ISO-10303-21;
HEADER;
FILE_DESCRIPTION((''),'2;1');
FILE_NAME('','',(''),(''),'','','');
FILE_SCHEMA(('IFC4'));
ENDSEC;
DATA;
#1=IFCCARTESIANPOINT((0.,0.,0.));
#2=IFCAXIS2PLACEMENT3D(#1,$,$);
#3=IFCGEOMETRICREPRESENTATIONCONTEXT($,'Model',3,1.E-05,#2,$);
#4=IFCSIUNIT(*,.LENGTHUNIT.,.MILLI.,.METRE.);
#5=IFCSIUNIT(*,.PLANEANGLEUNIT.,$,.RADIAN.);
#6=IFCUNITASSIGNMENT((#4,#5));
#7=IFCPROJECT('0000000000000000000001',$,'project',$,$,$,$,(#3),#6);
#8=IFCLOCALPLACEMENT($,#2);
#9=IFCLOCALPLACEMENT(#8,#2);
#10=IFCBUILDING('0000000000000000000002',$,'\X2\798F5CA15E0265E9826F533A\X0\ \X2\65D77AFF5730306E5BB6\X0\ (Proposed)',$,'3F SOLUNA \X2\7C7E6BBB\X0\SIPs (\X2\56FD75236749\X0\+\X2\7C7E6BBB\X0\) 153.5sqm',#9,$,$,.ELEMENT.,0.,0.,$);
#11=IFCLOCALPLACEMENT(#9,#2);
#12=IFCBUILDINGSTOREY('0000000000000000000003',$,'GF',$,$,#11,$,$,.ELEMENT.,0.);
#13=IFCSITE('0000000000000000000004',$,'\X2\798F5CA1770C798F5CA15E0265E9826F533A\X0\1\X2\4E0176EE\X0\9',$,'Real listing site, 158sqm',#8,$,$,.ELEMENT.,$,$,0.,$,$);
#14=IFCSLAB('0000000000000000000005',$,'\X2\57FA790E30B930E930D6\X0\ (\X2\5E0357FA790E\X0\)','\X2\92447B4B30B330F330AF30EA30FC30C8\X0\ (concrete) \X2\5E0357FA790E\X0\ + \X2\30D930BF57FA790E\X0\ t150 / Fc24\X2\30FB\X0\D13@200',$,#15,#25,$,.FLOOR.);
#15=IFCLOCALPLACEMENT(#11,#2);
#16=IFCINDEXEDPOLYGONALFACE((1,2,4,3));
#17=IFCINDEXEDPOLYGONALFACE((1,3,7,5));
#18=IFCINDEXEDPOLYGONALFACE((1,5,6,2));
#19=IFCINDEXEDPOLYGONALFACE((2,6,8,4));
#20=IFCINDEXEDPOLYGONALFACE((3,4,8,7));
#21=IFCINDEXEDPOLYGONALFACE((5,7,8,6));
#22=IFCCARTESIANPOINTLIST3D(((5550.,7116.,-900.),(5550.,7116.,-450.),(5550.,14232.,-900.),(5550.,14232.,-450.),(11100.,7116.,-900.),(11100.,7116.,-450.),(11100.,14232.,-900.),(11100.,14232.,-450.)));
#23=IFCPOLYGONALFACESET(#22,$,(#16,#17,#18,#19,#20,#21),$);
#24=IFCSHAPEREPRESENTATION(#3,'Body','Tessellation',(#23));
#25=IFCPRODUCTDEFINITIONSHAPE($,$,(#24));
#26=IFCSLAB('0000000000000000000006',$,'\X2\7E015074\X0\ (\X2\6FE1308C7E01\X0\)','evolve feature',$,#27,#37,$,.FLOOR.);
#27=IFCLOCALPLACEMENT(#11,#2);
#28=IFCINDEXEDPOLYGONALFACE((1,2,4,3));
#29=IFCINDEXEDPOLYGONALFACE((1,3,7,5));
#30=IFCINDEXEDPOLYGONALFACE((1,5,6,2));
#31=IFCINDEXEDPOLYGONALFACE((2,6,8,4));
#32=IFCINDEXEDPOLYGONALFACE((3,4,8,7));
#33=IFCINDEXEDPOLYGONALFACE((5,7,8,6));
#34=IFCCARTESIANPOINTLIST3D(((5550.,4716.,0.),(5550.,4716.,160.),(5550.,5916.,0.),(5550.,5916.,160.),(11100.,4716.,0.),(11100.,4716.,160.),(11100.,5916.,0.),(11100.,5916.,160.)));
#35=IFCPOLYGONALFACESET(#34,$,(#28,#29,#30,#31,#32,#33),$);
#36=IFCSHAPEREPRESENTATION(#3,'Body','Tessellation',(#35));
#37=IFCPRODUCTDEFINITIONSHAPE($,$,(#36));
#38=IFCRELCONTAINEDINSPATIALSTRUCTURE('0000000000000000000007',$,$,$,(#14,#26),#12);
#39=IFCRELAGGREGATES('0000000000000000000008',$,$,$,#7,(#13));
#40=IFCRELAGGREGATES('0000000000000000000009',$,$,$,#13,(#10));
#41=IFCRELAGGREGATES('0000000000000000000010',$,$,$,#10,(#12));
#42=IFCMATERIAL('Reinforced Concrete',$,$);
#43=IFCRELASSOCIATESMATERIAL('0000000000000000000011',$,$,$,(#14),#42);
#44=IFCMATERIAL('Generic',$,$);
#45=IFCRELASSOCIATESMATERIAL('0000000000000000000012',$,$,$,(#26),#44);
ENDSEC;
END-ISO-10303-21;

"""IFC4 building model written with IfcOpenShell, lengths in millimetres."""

from ifc_helpers import new_model, si_unit, frame, frame_2d, origin, place, context, project, spatial, rectangle, extrude, material, element, save


model = new_model("IFC4")

# Units and contexts
model_context = context("Model", 3, precision=1e-05, world=origin())
ifc_project = project(units=[si_unit("LENGTHUNIT", "METRE", prefix="MILLI"), si_unit("PLANEANGLEUNIT", "RADIAN")], contexts=[model_context])

# Site, building, storey
site_placement = place(None, origin())
site = spatial("IfcSite", under=ifc_project, at=site_placement, Name="福岡県福岡市早良区1丁目9", ObjectType="Real listing site, 158sqm", CompositionType="ELEMENT", RefElevation=0.0)
building_placement = place(site_placement, origin())
building = spatial("IfcBuilding", under=site, at=building_placement, Name="福岡市早良区 旗竿地の家 (Proposed)", ObjectType="3F SOLUNA 籾殻SIPs (国産杉+籾殻) 153.5sqm", CompositionType="ELEMENT", ElevationOfRefHeight=0.0, ElevationOfTerrain=0.0)
storey_placement = place(building_placement, origin())
storey = spatial("IfcBuildingStorey", under=building, at=storey_placement, Name="GF", CompositionType="ELEMENT", Elevation=0.0)

# Slabs
ifc_material_1 = material(Name="Reinforced Concrete")
slab_1_placement = place(storey_placement, frame((2775.0, 3558.0, -450.0)))
element("IfcSlab", 1, at=slab_1_placement, inside=storey, material=ifc_material_1, Name="基礎スラブ (布基礎)", Description="鉄筋コンクリート (concrete) 布基礎 + ベタ基礎 t150 / Fc24・D13@200", PredefinedType="FLOOR", context=model_context, shape_type="SweptSolid", body=[
    extrude(rectangle(XDim=5550.0, YDim=7116.0, at=frame_2d((2775.0, 3558.0))), frame((2775.0, 3558.0, -450.0)), (0.0, 0.0, 1.0), 450.0),
])
ifc_material_2 = material(Name="Generic")
slab_2_placement = place(storey_placement, frame((2775.0, 2358.0, 0.0)))
element("IfcSlab", 2, at=slab_2_placement, inside=storey, material=ifc_material_2, Name="縁側 (濡れ縁)", Description="evolve feature", PredefinedType="FLOOR", context=model_context, shape_type="SweptSolid", body=[
    extrude(rectangle(XDim=5550.0, YDim=1200.0, at=frame_2d((2775.0, 600.0))), frame((2775.0, 2358.0, 0.0)), (0.0, 0.0, 1.0), 160.0),
])

save(model, "model.ifc")
